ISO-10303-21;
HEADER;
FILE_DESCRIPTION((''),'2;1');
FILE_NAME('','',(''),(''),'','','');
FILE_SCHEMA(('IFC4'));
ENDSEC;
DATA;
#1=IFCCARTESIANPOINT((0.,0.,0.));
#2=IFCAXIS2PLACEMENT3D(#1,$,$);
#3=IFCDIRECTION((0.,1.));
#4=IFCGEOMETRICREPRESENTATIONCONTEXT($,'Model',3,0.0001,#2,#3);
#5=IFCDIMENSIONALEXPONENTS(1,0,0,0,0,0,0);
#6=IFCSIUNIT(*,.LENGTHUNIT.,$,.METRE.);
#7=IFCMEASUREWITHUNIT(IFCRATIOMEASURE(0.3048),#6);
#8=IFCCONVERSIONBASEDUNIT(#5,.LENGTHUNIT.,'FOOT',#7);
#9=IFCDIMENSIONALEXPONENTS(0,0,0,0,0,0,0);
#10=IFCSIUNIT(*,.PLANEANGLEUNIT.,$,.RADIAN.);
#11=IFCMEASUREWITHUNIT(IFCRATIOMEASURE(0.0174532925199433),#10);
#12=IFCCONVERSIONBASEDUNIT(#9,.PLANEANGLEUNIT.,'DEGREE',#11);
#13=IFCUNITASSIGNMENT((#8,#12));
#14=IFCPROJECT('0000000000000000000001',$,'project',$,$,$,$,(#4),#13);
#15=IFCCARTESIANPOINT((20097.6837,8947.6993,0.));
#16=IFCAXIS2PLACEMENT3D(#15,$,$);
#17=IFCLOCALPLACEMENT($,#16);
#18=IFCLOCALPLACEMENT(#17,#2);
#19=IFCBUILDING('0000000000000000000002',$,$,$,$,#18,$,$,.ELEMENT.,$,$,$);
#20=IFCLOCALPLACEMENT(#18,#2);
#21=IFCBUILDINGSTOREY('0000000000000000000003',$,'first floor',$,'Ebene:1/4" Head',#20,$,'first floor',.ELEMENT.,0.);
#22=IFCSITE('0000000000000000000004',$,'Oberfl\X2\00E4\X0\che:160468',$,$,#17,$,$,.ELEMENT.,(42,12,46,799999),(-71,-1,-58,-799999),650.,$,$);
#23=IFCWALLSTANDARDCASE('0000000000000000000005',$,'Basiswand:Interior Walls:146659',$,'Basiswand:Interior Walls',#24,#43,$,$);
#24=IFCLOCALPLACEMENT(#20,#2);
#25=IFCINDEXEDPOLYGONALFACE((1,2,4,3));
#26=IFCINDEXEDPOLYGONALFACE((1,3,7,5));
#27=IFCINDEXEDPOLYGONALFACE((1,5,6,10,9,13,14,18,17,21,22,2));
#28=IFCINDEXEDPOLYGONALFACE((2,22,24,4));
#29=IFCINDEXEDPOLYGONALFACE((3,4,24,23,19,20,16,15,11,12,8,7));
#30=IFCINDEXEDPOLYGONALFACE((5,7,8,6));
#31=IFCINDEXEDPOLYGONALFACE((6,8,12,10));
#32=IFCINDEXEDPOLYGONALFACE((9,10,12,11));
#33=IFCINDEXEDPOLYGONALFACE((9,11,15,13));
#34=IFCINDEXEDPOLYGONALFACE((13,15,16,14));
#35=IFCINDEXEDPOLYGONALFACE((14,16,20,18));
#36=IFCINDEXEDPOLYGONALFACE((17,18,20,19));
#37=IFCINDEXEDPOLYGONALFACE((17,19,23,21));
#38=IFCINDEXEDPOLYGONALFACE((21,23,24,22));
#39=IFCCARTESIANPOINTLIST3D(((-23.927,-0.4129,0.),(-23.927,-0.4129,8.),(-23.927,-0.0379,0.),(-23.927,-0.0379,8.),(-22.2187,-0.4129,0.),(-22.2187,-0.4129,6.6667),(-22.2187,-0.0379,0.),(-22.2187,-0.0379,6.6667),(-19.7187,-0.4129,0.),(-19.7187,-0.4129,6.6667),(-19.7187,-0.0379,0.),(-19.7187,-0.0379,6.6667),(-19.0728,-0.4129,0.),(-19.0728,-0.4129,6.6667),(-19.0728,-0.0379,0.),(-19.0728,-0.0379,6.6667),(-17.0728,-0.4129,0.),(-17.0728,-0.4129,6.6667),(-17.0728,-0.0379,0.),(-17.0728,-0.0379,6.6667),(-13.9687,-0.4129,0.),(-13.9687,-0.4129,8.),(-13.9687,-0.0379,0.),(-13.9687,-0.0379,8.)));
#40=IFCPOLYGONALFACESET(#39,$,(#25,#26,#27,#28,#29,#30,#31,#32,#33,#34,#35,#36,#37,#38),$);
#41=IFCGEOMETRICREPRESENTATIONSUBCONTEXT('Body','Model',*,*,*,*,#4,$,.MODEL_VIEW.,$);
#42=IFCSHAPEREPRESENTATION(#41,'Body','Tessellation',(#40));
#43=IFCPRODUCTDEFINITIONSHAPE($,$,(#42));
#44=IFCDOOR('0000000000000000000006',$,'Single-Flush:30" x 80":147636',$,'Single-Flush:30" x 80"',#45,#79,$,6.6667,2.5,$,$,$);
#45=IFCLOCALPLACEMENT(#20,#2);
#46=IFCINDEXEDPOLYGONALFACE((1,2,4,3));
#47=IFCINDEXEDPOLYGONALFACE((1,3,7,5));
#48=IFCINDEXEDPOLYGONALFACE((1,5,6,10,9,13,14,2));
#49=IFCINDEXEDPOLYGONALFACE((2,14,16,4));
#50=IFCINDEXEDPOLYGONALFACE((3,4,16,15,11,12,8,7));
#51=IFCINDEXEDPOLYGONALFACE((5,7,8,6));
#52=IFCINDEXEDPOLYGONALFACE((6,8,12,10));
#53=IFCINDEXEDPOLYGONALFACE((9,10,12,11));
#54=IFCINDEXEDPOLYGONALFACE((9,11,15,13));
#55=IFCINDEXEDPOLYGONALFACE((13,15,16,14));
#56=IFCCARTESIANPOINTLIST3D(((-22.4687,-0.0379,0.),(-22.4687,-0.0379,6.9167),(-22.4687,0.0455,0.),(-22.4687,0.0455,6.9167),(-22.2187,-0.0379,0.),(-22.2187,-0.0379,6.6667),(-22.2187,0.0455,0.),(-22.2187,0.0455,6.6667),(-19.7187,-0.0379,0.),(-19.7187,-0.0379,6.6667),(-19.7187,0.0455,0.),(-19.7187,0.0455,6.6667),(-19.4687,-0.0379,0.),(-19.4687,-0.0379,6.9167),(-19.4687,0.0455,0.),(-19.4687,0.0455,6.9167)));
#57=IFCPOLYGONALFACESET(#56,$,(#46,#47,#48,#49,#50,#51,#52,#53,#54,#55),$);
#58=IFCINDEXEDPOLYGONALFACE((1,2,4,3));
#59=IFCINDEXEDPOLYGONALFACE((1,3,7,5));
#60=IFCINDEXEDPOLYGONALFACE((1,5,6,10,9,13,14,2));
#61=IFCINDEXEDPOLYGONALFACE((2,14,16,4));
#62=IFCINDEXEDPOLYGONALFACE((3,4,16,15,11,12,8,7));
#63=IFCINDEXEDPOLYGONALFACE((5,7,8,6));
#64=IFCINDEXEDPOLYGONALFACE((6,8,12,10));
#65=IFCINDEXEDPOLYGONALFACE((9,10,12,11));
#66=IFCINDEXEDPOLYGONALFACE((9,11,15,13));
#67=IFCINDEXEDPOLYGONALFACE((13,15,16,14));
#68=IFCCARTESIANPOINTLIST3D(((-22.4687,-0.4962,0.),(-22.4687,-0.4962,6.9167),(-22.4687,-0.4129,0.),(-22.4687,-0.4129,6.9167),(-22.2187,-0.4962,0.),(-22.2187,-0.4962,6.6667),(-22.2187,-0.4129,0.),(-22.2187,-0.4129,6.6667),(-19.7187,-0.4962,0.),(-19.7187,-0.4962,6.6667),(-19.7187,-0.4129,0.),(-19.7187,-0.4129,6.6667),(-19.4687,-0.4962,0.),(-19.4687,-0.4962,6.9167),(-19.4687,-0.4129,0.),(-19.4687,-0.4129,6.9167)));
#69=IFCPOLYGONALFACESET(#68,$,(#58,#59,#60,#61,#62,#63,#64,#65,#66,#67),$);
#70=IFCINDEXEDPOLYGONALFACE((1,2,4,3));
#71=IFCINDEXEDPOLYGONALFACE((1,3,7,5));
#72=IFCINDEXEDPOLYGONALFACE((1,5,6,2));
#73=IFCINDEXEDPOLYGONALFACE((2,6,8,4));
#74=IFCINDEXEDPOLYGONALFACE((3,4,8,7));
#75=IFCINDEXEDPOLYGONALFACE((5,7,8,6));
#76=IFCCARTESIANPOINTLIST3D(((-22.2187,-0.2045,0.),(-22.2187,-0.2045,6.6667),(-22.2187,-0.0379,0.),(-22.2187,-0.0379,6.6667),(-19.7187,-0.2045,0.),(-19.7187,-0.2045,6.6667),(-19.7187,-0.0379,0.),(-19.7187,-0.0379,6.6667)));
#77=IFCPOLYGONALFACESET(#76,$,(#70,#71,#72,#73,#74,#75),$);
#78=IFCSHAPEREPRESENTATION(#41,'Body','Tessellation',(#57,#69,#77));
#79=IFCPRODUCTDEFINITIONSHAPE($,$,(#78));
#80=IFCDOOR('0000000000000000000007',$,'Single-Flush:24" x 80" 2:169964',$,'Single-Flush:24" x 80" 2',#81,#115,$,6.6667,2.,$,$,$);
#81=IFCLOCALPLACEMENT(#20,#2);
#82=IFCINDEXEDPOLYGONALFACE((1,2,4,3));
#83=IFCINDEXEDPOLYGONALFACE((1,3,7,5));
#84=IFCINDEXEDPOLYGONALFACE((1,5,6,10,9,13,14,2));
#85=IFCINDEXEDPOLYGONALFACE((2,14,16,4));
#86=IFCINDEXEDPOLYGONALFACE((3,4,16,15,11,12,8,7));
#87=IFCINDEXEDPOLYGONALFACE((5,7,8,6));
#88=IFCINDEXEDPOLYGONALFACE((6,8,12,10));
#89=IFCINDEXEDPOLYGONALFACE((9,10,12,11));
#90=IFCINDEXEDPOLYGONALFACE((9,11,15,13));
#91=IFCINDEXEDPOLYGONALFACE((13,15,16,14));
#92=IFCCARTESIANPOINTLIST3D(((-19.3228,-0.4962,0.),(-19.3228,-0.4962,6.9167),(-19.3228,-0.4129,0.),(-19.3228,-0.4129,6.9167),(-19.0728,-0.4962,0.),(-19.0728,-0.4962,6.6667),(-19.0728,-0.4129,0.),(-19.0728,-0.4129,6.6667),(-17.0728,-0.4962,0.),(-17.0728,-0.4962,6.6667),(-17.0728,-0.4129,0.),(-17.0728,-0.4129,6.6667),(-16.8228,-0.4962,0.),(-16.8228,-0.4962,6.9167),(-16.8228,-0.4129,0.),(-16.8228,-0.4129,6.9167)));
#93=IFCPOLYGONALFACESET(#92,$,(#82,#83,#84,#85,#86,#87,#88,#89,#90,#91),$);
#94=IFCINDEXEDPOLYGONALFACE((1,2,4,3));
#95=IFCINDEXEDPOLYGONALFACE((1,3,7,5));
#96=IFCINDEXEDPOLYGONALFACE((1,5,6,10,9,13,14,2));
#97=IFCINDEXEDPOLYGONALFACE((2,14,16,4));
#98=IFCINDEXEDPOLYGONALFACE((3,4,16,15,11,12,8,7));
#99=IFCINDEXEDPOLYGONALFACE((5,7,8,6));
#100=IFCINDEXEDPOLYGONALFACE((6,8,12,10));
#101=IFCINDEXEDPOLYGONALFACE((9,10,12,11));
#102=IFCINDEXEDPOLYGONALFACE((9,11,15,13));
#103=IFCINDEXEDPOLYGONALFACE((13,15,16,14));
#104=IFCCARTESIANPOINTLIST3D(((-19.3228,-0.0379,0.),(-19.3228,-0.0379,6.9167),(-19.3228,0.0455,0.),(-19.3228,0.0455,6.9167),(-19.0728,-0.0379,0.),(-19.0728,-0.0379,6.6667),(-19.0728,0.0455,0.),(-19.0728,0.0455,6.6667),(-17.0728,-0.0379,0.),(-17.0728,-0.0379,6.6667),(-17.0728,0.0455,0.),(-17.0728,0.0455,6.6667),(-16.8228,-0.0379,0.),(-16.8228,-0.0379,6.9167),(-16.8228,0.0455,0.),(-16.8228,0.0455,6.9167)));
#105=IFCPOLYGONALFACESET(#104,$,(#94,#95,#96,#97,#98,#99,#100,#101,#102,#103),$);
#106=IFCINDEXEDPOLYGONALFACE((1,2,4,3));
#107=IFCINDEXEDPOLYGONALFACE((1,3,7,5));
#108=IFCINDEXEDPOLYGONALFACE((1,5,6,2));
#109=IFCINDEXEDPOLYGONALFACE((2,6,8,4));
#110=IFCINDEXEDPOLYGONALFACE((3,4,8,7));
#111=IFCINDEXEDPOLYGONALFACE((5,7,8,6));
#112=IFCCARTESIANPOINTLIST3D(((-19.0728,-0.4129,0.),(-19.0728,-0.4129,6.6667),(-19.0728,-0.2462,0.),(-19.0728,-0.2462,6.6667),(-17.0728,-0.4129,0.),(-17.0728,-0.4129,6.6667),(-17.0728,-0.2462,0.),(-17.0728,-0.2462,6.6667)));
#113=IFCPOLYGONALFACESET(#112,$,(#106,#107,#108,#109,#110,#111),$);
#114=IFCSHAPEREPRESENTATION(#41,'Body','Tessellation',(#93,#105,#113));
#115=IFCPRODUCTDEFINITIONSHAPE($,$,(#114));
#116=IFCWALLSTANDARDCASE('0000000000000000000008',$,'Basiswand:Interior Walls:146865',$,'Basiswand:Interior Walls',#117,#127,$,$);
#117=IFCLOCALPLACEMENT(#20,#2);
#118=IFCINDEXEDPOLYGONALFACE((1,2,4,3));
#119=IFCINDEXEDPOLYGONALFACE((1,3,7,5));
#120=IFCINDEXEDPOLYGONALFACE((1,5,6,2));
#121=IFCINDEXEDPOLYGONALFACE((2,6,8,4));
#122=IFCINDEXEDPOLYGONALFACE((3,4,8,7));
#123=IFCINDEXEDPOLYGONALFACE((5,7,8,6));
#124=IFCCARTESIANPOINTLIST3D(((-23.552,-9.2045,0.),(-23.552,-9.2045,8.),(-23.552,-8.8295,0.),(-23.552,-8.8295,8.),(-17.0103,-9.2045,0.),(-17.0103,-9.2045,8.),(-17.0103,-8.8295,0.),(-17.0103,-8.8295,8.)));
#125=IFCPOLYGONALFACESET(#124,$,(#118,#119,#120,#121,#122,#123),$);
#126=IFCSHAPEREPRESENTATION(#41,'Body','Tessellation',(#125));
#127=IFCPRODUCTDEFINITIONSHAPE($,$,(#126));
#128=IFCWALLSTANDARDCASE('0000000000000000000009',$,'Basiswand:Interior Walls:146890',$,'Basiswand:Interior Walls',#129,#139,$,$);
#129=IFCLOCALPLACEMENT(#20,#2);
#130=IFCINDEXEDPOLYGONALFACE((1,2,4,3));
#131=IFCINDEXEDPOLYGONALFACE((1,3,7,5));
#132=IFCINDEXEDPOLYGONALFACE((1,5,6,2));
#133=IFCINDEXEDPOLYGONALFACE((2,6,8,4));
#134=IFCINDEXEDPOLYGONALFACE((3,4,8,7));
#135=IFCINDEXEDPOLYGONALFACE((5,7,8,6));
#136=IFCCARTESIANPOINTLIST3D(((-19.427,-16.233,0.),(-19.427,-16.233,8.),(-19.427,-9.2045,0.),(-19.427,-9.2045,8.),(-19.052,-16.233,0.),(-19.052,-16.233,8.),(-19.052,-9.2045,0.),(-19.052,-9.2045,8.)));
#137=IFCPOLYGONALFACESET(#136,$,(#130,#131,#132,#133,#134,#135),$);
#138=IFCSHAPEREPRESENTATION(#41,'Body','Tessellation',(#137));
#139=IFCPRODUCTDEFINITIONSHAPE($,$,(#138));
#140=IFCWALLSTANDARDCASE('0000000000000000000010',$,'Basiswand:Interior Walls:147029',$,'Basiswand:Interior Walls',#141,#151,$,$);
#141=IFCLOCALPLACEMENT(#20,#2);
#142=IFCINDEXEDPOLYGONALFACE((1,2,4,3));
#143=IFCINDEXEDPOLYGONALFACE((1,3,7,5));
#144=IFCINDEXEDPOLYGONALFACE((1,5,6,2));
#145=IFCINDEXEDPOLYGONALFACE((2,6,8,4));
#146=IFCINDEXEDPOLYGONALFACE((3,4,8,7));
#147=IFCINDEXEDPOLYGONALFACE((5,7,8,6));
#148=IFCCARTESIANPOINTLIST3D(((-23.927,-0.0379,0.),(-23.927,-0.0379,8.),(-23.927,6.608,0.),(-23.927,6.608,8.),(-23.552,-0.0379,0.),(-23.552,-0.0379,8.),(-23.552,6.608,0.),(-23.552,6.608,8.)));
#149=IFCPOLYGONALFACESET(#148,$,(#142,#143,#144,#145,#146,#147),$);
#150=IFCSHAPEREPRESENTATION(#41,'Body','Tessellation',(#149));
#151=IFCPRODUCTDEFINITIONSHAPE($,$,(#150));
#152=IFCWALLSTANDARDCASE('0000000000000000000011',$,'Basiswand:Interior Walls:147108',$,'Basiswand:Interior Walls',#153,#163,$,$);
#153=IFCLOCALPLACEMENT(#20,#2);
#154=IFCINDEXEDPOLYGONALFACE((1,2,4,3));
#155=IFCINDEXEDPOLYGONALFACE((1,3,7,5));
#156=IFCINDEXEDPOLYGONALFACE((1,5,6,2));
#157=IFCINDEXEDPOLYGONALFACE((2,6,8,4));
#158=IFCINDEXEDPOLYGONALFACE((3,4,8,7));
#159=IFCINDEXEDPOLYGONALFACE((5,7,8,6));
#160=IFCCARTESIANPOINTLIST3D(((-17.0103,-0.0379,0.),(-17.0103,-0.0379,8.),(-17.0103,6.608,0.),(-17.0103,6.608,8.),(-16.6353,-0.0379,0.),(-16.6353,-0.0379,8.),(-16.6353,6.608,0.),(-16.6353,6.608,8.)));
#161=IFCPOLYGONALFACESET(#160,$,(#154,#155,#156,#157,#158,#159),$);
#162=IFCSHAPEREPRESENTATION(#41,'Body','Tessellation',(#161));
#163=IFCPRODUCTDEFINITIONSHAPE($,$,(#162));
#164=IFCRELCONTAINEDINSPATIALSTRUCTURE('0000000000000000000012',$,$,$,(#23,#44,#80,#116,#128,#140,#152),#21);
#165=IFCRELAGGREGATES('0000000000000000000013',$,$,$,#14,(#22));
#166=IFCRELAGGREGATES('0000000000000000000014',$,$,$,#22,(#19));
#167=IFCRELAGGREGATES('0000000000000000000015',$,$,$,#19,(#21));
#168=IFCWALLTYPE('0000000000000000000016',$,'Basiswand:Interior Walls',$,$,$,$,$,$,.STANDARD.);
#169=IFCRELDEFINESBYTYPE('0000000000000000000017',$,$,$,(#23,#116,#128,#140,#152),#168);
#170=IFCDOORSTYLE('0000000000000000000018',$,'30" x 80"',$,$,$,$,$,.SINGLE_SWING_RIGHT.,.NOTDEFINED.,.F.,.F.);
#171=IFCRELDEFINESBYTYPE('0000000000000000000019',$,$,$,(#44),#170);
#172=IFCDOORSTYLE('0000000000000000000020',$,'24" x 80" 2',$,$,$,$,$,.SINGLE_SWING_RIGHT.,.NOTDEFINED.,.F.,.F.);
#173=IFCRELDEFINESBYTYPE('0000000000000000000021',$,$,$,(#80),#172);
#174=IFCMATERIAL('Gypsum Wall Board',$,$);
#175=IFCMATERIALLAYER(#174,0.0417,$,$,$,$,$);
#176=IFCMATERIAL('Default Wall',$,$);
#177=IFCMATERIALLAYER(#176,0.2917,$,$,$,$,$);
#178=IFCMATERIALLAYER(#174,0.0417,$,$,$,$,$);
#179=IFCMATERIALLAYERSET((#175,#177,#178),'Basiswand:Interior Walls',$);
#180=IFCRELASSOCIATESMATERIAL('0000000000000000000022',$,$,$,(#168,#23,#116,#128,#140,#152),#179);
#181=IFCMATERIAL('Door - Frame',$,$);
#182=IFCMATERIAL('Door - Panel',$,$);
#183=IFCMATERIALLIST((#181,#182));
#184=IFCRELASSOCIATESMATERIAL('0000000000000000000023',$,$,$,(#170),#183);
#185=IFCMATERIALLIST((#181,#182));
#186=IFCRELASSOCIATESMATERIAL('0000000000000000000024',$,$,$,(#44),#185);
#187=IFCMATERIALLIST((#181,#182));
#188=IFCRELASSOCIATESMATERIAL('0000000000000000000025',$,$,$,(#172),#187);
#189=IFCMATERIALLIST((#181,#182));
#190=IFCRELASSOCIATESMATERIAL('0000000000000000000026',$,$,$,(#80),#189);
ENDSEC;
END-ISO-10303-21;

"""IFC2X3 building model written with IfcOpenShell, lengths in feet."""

from ifc_helpers import new_model, entity, si_unit, converted_unit, direction, frame, frame_2d, origin, origin_2d_with_axis, place, context, subcontext, project, spatial, polyline, rectangle, outline, extrude, source, transform, mapped, material, material_list, layer, layer_set, layer_usage, type_object, type_shapes, element, fill, save


model = new_model("IFC2X3")

# Units and contexts
model_context = context("Model", 3, precision=0.0001, world=origin(), true_north=direction((0.0, 1.0)))
body_context = subcontext(model_context, "Body", "Model", "MODEL_VIEW")
ifc_project = project(units=[converted_unit("LENGTHUNIT", "FOOT", entity("IfcRatioMeasure", 0.3048), si_unit("LENGTHUNIT", "METRE"), dimensions=[1, 0, 0, 0, 0, 0, 0]), converted_unit("PLANEANGLEUNIT", "DEGREE", entity("IfcRatioMeasure", 0.0174532925199433), si_unit("PLANEANGLEUNIT", "RADIAN"), dimensions=[0, 0, 0, 0, 0, 0, 0])], contexts=[model_context])

# Site, building, storey
site_placement = place(None, frame((20097.6837, 8947.6993, 0.0)))
site = spatial("IfcSite", under=ifc_project, at=site_placement, Name="Oberfläche:160468", CompositionType="ELEMENT", RefLatitude=(42, 12, 46, 799999), RefLongitude=(-71, -1, -58, -799999), RefElevation=650.0)
building_placement = place(site_placement, origin())
building = spatial("IfcBuilding", under=site, at=building_placement, CompositionType="ELEMENT")
storey_placement = place(building_placement, origin())
storey = spatial("IfcBuildingStorey", under=building, at=storey_placement, Name="first floor", ObjectType="Ebene:1/4\" Head", LongName="first floor", CompositionType="ELEMENT", Elevation=0.0)

# Shared definitions
ifc_material_1 = material(Name="Gypsum Wall Board")

# Wall, openings, doors
ifc_layer_1 = layer(ifc_material_1, 0.0417)
ifc_material_2 = material(Name="Default Wall")
ifc_layer_2 = layer(ifc_material_2, 0.2917)
ifc_layer_3 = layer(ifc_material_1, 0.0417)
ifc_layer_set_1 = layer_set([ifc_layer_1, ifc_layer_2, ifc_layer_3], Name="Basiswand:Interior Walls")
ifc_layer_usage_1 = layer_usage(ifc_layer_set_1, "AXIS2", "POSITIVE", -0.1875)
wall_type_1 = type_object("IfcWallType", Name="Basiswand:Interior Walls", PredefinedType="STANDARD", material=ifc_layer_set_1)
wall_1_placement = place(storey_placement, frame((-13.9687, -0.2254, 0.0), z_axis=(0.0, 0.0, 1.0), x_axis=(-1.0, 0.0, 0.0)))
wall_1 = element("IfcWallStandardCase", 1, at=wall_1_placement, inside=storey, type_object=wall_type_1, material=ifc_layer_usage_1, Name="Basiswand:Interior Walls:146659", ObjectType="Basiswand:Interior Walls", context=body_context, shape_type="SweptSolid", body=[
    extrude(rectangle(XDim=9.9583, YDim=0.375, at=frame_2d((4.9792, 0.0), x_axis=(-1.0, 0.0))), origin(), (0.0, 0.0, 1.0), 8.0),
])
opening_1_placement = place(wall_1_placement, frame((8.25, 0.1875, 0.0)))
opening_1 = element("IfcOpeningElement", 2, at=opening_1_placement, cuts=wall_1, ObjectType="Opening", context=body_context, shape_type="SweptSolid", body=[
    extrude(rectangle(XDim=2.5, YDim=6.6667, at=frame_2d((3.3333, 1.25), x_axis=(0.0, 1.0))), frame((0.0, 0.0, 0.0), z_axis=(0.0, -1.0, 0.0), x_axis=(0.0, 0.0, 1.0)), (0.0, 0.0, 1.0), 0.375),
])
opening_2_placement = place(wall_1_placement, frame((3.1042, -0.1875, 0.0)))
opening_2 = element("IfcOpeningElement", 3, at=opening_2_placement, cuts=wall_1, ObjectType="Opening", context=body_context, shape_type="SweptSolid", body=[
    extrude(rectangle(XDim=2.0, YDim=6.6667, at=frame_2d((3.3333, 1.0), x_axis=(0.0, 1.0))), frame((0.0, 0.0, 0.0), z_axis=(0.0, 1.0, 0.0), x_axis=(0.0, 0.0, 1.0)), (0.0, 0.0, 1.0), 0.375),
])
ifc_material_3 = material(Name="Door - Frame")
ifc_material_4 = material(Name="Door - Panel")
ifc_material_list_1 = material_list([ifc_material_3, ifc_material_4])
ifc_material_list_2 = material_list([ifc_material_3, ifc_material_4])
door_style_1 = type_object("IfcDoorStyle", Name="30\" x 80\"", ConstructionType="NOTDEFINED", OperationType="SINGLE_SWING_RIGHT", ParameterTakesPrecedence=False, Sizeable=False, material=ifc_material_list_2)
shared_shape_1 = source(origin(), body_context, "Body", "SweptSolid", [
    extrude(outline(polyline([(-1.5, -3.5208), (1.5, -3.5208), (1.5, 3.3958), (1.25, 3.3958), (1.25, -3.2708), (-1.25, -3.2708), (-1.25, 3.3958), (-1.5, 3.3958), (-1.5, -3.5208)])), frame((1.25, 0.375, 3.3958), z_axis=(0.0, 1.0, 0.0), x_axis=(1.0, 0.0, 0.0)), (0.0, 0.0, 1.0), 0.0833),
    extrude(outline(polyline([(-3.5208, -1.5), (3.3958, -1.5), (3.3958, -1.25), (-3.2708, -1.25), (-3.2708, 1.25), (3.3958, 1.25), (3.3958, 1.5), (-3.5208, 1.5), (-3.5208, -1.5)])), frame((1.25, -0.0833, 3.3958), z_axis=(0.0, 1.0, 0.0), x_axis=(0.0, 0.0, -1.0)), (0.0, 0.0, 1.0), 0.0833),
    extrude(rectangle(XDim=0.1667, YDim=2.5, at=origin_2d_with_axis()), frame((1.25, 0.2917, 0.0), z_axis=(0.0, 0.0, 1.0), x_axis=(0.0, 1.0, 0.0)), (0.0, 0.0, 1.0), 6.6667),
])
type_shapes(door_style_1, [shared_shape_1])
door_1_placement = place(opening_1_placement, frame((0.0, 0.0, 0.0), z_axis=(0.0, 0.0, 1.0), x_axis=(-1.0, 0.0, 0.0)))
door_1 = element("IfcDoor", 4, at=door_1_placement, inside=storey, type_object=door_style_1, material=ifc_material_list_1, Name="Single-Flush:30\" x 80\":147636", ObjectType="Single-Flush:30\" x 80\"", OverallHeight=6.6667, OverallWidth=2.5, context=body_context, shape_type="MappedRepresentation", body=[
    mapped(shared_shape_1, transform((0.0, 0.0, 0.0), scale=1.0)),
])
fill(opening_1, door_1)
ifc_material_list_3 = material_list([ifc_material_3, ifc_material_4])
ifc_material_list_4 = material_list([ifc_material_3, ifc_material_4])
door_style_2 = type_object("IfcDoorStyle", Name="24\" x 80\" 2", ConstructionType="NOTDEFINED", OperationType="SINGLE_SWING_RIGHT", ParameterTakesPrecedence=False, Sizeable=False, material=ifc_material_list_4)
shared_shape_2 = source(origin(), body_context, "Body", "SweptSolid", [
    extrude(outline(polyline([(-1.25, -3.5208), (1.25, -3.5208), (1.25, 3.3958), (1.0, 3.3958), (1.0, -3.2708), (-1.0, -3.2708), (-1.0, 3.3958), (-1.25, 3.3958), (-1.25, -3.5208)])), frame((1.0, 0.375, 3.3958), z_axis=(0.0, 1.0, 0.0), x_axis=(1.0, 0.0, 0.0)), (0.0, 0.0, 1.0), 0.0833),
    extrude(outline(polyline([(-3.5208, -1.25), (3.3958, -1.25), (3.3958, -1.0), (-3.2708, -1.0), (-3.2708, 1.0), (3.3958, 1.0), (3.3958, 1.25), (-3.5208, 1.25), (-3.5208, -1.25)])), frame((1.0, -0.0833, 3.3958), z_axis=(0.0, 1.0, 0.0), x_axis=(0.0, 0.0, -1.0)), (0.0, 0.0, 1.0), 0.0833),
    extrude(rectangle(XDim=0.1667, YDim=2.0, at=origin_2d_with_axis()), frame((1.0, 0.2917, 0.0), z_axis=(0.0, 0.0, 1.0), x_axis=(0.0, 1.0, 0.0)), (0.0, 0.0, 1.0), 6.6667),
])
type_shapes(door_style_2, [shared_shape_2])
door_2_placement = place(opening_2_placement, origin())
door_2 = element("IfcDoor", 5, at=door_2_placement, inside=storey, type_object=door_style_2, material=ifc_material_list_3, Name="Single-Flush:24\" x 80\" 2:169964", ObjectType="Single-Flush:24\" x 80\" 2", OverallHeight=6.6667, OverallWidth=2.0, context=body_context, shape_type="MappedRepresentation", body=[
    mapped(shared_shape_2, transform((0.0, 0.0, 0.0), scale=1.0)),
])
fill(opening_2, door_2)

# Walls
ifc_layer_usage_2 = layer_usage(ifc_layer_set_1, "AXIS2", "NEGATIVE", 0.1875)
wall_2_placement = place(storey_placement, frame((-17.0103, -9.017, 0.0), z_axis=(0.0, 0.0, 1.0), x_axis=(-1.0, 0.0, 0.0)))
element("IfcWallStandardCase", 6, at=wall_2_placement, inside=storey, type_object=wall_type_1, material=ifc_layer_usage_2, Name="Basiswand:Interior Walls:146865", ObjectType="Basiswand:Interior Walls", context=body_context, shape_type="SweptSolid", body=[
    extrude(rectangle(XDim=6.5417, YDim=0.375, at=frame_2d((3.2708, 0.0), x_axis=(-1.0, 0.0))), origin(), (0.0, 0.0, 1.0), 8.0),
])
ifc_layer_usage_3 = layer_usage(ifc_layer_set_1, "AXIS2", "NEGATIVE", 0.1875)
wall_3_placement = place(storey_placement, frame((-19.2395, -9.2045, 0.0), z_axis=(0.0, 0.0, 1.0), x_axis=(0.0, -1.0, 0.0)))
element("IfcWallStandardCase", 7, at=wall_3_placement, inside=storey, type_object=wall_type_1, material=ifc_layer_usage_3, Name="Basiswand:Interior Walls:146890", ObjectType="Basiswand:Interior Walls", context=body_context, shape_type="SweptSolid", body=[
    extrude(rectangle(XDim=7.0284, YDim=0.375, at=frame_2d((3.5142, 0.0), x_axis=(-1.0, 0.0))), origin(), (0.0, 0.0, 1.0), 8.0),
])
ifc_layer_usage_4 = layer_usage(ifc_layer_set_1, "AXIS2", "NEGATIVE", 0.1875)
wall_4_placement = place(storey_placement, frame((-23.7395, -0.0379, 0.0), z_axis=(0.0, 0.0, 1.0), x_axis=(0.0, 1.0, 0.0)))
element("IfcWallStandardCase", 8, at=wall_4_placement, inside=storey, type_object=wall_type_1, material=ifc_layer_usage_4, Name="Basiswand:Interior Walls:147029", ObjectType="Basiswand:Interior Walls", context=body_context, shape_type="SweptSolid", body=[
    extrude(rectangle(XDim=6.6458, YDim=0.375, at=frame_2d((3.3229, 0.0), x_axis=(-1.0, 0.0))), origin(), (0.0, 0.0, 1.0), 8.0),
])
ifc_layer_usage_5 = layer_usage(ifc_layer_set_1, "AXIS2", "POSITIVE", -0.1875)
wall_5_placement = place(storey_placement, frame((-16.8228, -0.0379, 0.0), z_axis=(0.0, 0.0, 1.0), x_axis=(0.0, 1.0, 0.0)))
element("IfcWallStandardCase", 9, at=wall_5_placement, inside=storey, type_object=wall_type_1, material=ifc_layer_usage_5, Name="Basiswand:Interior Walls:147108", ObjectType="Basiswand:Interior Walls", context=body_context, shape_type="SweptSolid", body=[
    extrude(rectangle(XDim=6.6458, YDim=0.375, at=frame_2d((3.3229, 0.0), x_axis=(-1.0, 0.0))), origin(), (0.0, 0.0, 1.0), 8.0),
])

save(model, "model.ifc")
